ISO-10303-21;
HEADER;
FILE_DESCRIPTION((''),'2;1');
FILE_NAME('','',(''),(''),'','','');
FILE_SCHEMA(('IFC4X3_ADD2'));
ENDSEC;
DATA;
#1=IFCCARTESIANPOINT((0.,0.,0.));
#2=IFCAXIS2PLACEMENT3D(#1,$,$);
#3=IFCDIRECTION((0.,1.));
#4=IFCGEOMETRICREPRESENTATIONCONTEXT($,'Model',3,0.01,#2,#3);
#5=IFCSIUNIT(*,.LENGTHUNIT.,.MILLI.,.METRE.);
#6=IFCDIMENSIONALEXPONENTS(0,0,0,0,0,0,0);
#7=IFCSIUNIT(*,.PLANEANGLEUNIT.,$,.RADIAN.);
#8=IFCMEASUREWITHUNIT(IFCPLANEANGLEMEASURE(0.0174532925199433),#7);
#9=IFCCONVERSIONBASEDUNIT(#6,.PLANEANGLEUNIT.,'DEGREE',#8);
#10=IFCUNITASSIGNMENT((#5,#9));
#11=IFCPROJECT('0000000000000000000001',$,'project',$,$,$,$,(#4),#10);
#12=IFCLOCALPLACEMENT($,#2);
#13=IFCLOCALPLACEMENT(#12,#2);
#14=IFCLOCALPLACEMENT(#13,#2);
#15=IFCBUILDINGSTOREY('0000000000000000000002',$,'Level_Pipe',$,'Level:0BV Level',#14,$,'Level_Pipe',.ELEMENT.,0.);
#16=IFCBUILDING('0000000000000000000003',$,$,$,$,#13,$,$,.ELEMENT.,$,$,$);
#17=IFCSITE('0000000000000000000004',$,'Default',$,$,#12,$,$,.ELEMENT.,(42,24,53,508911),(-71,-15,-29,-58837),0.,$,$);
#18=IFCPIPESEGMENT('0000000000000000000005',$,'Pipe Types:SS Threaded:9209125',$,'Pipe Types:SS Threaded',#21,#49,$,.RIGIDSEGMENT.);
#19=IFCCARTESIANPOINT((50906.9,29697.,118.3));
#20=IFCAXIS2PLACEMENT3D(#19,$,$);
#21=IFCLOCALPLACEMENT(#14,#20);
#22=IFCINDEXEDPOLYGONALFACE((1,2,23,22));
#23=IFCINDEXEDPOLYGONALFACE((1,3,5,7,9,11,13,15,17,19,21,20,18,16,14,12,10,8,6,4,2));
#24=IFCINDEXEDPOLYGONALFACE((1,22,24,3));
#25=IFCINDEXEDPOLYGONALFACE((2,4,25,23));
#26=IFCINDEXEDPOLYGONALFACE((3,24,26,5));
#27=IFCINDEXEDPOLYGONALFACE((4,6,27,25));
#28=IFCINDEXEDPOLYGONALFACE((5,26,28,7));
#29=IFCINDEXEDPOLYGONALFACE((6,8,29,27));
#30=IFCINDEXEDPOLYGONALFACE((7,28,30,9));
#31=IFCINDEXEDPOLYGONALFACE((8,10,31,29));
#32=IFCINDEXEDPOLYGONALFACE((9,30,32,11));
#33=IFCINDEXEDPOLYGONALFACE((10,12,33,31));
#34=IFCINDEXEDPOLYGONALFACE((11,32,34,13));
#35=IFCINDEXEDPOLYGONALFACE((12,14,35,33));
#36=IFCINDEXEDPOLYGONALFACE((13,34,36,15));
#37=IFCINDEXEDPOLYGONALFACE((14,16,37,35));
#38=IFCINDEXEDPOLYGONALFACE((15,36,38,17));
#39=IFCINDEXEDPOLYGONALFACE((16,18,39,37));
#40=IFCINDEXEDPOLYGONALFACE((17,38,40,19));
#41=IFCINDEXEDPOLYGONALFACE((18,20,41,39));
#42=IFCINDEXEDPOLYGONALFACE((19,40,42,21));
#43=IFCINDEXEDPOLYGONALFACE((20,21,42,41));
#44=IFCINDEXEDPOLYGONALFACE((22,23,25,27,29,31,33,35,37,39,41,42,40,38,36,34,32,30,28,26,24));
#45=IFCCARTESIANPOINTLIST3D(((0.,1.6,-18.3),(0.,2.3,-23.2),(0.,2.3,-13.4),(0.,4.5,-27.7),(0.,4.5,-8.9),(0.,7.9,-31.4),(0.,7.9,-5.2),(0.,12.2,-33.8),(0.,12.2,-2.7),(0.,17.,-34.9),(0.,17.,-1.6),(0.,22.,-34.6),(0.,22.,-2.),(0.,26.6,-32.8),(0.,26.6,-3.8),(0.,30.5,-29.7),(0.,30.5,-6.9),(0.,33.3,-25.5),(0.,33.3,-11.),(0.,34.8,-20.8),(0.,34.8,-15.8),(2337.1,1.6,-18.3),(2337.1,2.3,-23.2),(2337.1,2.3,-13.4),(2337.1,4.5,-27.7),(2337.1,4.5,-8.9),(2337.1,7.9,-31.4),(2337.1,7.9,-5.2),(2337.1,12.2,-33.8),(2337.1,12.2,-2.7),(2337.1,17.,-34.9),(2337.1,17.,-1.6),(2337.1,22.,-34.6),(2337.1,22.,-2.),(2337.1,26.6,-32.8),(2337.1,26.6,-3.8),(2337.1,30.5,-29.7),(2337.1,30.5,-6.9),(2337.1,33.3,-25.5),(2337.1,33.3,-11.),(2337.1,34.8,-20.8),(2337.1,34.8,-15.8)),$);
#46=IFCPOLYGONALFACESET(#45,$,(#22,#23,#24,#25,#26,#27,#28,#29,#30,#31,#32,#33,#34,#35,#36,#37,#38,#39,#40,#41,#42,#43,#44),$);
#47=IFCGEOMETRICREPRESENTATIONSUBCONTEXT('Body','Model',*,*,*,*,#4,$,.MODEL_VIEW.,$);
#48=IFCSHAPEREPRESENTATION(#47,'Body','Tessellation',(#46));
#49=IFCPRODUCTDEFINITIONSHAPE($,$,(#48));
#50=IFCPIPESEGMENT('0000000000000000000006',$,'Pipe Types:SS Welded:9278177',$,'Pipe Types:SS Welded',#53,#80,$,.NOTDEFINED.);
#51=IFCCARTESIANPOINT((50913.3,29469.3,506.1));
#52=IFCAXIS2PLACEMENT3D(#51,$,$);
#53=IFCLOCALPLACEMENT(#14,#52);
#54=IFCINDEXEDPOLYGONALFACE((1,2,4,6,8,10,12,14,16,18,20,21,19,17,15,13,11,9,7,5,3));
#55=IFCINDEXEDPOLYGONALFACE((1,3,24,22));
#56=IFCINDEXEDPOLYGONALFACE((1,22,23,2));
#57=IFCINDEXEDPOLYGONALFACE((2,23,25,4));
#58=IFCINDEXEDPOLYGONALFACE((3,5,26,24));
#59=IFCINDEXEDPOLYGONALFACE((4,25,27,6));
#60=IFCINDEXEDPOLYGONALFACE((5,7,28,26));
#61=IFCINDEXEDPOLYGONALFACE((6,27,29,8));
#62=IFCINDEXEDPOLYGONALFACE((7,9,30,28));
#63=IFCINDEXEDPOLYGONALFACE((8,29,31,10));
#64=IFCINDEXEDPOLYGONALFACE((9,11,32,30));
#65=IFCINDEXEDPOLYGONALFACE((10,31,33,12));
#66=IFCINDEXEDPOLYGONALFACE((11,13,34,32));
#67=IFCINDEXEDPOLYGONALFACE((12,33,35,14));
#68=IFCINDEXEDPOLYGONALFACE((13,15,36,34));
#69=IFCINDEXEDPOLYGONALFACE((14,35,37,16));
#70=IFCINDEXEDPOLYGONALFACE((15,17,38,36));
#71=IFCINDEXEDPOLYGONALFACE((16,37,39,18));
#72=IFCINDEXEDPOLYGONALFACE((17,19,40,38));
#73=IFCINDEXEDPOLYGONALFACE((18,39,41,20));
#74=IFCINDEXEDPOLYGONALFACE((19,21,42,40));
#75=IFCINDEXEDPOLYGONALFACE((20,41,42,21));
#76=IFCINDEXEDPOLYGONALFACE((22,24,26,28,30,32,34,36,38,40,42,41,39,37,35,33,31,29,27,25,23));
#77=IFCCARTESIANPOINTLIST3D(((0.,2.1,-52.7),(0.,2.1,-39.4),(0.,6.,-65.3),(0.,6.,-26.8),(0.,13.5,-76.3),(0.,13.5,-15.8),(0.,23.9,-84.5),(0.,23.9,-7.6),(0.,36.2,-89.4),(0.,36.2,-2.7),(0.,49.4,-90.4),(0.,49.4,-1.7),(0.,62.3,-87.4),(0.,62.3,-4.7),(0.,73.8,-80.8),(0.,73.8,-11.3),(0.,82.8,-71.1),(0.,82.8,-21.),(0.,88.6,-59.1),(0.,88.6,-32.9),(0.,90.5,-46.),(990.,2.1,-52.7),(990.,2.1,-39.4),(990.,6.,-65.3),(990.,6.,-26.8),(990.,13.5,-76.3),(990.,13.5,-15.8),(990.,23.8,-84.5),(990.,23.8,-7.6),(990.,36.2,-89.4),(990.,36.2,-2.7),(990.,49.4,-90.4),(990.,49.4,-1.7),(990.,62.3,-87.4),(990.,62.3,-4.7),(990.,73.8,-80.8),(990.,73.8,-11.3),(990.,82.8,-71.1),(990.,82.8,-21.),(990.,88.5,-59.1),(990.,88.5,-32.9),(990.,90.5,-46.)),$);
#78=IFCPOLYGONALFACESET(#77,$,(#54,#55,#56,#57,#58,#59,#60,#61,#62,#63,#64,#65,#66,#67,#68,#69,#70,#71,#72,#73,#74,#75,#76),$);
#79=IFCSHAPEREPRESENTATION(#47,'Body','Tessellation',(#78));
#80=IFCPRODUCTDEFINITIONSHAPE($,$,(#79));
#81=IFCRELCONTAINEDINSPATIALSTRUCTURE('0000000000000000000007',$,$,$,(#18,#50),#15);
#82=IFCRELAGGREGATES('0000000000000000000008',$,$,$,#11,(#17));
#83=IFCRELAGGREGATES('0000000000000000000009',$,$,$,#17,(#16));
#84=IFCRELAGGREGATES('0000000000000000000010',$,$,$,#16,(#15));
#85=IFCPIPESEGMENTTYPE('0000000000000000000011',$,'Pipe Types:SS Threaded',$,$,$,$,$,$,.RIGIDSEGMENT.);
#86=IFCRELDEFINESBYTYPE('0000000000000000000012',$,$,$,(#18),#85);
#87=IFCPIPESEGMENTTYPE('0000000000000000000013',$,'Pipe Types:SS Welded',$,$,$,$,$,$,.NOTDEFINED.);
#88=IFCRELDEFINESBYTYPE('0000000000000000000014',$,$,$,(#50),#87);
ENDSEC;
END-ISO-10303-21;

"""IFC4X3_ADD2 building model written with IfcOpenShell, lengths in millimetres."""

from ifc_helpers import new_model, entity, si_unit, converted_unit, direction, frame, frame_2d, origin, place, context, subcontext, project, spatial, circle, extrude, type_object, element, save


model = new_model("IFC4X3_ADD2")

# Units and contexts
model_context = context("Model", 3, precision=0.01, world=origin(), true_north=direction((0.0, 1.0)))
body_context = subcontext(model_context, "Body", "Model", "MODEL_VIEW")
ifc_project = project(units=[si_unit("LENGTHUNIT", "METRE", prefix="MILLI"), converted_unit("PLANEANGLEUNIT", "DEGREE", entity("IfcPlaneAngleMeasure", 0.0174532925199433), si_unit("PLANEANGLEUNIT", "RADIAN"), dimensions=[0, 0, 0, 0, 0, 0, 0])], contexts=[model_context])

# Site, building, storey
site_placement = place(None, origin())
site = spatial("IfcSite", under=ifc_project, at=site_placement, Name="Default", CompositionType="ELEMENT", RefLatitude=(42, 24, 53, 508911), RefLongitude=(-71, -15, -29, -58837), RefElevation=0.0)
building_placement = place(site_placement, origin())
building = spatial("IfcBuilding", under=site, at=building_placement, CompositionType="ELEMENT")
storey_placement = place(building_placement, origin())
storey = spatial("IfcBuildingStorey", under=building, at=storey_placement, Name="Level_Pipe", ObjectType="Level:0BV Level", LongName="Level_Pipe", CompositionType="ELEMENT", Elevation=0.0)

# Pipe segment
pipe_segment_type_1 = type_object("IfcPipeSegmentType", Name="Pipe Types:SS Threaded", PredefinedType="RIGIDSEGMENT")
pipe_segment_1_placement = place(storey_placement, frame((50906.9, 29697.0, 118.3)))
element("IfcPipeSegment", 1, at=pipe_segment_1_placement, inside=storey, type_object=pipe_segment_type_1, Name="Pipe Types:SS Threaded:9209125", ObjectType="Pipe Types:SS Threaded", PredefinedType="RIGIDSEGMENT", context=body_context, shape_type="SweptSolid", body=[
    extrude(circle(Radius=16.7, at=frame_2d((0.0, 0.0), x_axis=(1.0, 0.0))), frame((0.0, 18.3, -18.3), z_axis=(1.0, 0.0, 0.0), x_axis=(0.0, -1.0, 0.0)), (0.0, 0.0, 1.0), 2337.1),
])

# Pipe segment
pipe_segment_type_2 = type_object("IfcPipeSegmentType", Name="Pipe Types:SS Welded", PredefinedType="NOTDEFINED")
pipe_segment_2_placement = place(storey_placement, frame((50913.3, 29469.3, 506.1)))
element("IfcPipeSegment", 2, at=pipe_segment_2_placement, inside=storey, type_object=pipe_segment_type_2, Name="Pipe Types:SS Welded:9278177", ObjectType="Pipe Types:SS Welded", PredefinedType="NOTDEFINED", context=body_context, shape_type="SweptSolid", body=[
    extrude(circle(Radius=44.5, at=frame_2d((0.0, 0.0), x_axis=(1.0, 0.0))), frame((0.0, 46.1, -46.0), z_axis=(1.0, -0.00003, 0.0), x_axis=(0.00003, 1.0, 0.0)), (0.0, 0.0, 1.0), 990.0),
])

save(model, "model.ifc")
